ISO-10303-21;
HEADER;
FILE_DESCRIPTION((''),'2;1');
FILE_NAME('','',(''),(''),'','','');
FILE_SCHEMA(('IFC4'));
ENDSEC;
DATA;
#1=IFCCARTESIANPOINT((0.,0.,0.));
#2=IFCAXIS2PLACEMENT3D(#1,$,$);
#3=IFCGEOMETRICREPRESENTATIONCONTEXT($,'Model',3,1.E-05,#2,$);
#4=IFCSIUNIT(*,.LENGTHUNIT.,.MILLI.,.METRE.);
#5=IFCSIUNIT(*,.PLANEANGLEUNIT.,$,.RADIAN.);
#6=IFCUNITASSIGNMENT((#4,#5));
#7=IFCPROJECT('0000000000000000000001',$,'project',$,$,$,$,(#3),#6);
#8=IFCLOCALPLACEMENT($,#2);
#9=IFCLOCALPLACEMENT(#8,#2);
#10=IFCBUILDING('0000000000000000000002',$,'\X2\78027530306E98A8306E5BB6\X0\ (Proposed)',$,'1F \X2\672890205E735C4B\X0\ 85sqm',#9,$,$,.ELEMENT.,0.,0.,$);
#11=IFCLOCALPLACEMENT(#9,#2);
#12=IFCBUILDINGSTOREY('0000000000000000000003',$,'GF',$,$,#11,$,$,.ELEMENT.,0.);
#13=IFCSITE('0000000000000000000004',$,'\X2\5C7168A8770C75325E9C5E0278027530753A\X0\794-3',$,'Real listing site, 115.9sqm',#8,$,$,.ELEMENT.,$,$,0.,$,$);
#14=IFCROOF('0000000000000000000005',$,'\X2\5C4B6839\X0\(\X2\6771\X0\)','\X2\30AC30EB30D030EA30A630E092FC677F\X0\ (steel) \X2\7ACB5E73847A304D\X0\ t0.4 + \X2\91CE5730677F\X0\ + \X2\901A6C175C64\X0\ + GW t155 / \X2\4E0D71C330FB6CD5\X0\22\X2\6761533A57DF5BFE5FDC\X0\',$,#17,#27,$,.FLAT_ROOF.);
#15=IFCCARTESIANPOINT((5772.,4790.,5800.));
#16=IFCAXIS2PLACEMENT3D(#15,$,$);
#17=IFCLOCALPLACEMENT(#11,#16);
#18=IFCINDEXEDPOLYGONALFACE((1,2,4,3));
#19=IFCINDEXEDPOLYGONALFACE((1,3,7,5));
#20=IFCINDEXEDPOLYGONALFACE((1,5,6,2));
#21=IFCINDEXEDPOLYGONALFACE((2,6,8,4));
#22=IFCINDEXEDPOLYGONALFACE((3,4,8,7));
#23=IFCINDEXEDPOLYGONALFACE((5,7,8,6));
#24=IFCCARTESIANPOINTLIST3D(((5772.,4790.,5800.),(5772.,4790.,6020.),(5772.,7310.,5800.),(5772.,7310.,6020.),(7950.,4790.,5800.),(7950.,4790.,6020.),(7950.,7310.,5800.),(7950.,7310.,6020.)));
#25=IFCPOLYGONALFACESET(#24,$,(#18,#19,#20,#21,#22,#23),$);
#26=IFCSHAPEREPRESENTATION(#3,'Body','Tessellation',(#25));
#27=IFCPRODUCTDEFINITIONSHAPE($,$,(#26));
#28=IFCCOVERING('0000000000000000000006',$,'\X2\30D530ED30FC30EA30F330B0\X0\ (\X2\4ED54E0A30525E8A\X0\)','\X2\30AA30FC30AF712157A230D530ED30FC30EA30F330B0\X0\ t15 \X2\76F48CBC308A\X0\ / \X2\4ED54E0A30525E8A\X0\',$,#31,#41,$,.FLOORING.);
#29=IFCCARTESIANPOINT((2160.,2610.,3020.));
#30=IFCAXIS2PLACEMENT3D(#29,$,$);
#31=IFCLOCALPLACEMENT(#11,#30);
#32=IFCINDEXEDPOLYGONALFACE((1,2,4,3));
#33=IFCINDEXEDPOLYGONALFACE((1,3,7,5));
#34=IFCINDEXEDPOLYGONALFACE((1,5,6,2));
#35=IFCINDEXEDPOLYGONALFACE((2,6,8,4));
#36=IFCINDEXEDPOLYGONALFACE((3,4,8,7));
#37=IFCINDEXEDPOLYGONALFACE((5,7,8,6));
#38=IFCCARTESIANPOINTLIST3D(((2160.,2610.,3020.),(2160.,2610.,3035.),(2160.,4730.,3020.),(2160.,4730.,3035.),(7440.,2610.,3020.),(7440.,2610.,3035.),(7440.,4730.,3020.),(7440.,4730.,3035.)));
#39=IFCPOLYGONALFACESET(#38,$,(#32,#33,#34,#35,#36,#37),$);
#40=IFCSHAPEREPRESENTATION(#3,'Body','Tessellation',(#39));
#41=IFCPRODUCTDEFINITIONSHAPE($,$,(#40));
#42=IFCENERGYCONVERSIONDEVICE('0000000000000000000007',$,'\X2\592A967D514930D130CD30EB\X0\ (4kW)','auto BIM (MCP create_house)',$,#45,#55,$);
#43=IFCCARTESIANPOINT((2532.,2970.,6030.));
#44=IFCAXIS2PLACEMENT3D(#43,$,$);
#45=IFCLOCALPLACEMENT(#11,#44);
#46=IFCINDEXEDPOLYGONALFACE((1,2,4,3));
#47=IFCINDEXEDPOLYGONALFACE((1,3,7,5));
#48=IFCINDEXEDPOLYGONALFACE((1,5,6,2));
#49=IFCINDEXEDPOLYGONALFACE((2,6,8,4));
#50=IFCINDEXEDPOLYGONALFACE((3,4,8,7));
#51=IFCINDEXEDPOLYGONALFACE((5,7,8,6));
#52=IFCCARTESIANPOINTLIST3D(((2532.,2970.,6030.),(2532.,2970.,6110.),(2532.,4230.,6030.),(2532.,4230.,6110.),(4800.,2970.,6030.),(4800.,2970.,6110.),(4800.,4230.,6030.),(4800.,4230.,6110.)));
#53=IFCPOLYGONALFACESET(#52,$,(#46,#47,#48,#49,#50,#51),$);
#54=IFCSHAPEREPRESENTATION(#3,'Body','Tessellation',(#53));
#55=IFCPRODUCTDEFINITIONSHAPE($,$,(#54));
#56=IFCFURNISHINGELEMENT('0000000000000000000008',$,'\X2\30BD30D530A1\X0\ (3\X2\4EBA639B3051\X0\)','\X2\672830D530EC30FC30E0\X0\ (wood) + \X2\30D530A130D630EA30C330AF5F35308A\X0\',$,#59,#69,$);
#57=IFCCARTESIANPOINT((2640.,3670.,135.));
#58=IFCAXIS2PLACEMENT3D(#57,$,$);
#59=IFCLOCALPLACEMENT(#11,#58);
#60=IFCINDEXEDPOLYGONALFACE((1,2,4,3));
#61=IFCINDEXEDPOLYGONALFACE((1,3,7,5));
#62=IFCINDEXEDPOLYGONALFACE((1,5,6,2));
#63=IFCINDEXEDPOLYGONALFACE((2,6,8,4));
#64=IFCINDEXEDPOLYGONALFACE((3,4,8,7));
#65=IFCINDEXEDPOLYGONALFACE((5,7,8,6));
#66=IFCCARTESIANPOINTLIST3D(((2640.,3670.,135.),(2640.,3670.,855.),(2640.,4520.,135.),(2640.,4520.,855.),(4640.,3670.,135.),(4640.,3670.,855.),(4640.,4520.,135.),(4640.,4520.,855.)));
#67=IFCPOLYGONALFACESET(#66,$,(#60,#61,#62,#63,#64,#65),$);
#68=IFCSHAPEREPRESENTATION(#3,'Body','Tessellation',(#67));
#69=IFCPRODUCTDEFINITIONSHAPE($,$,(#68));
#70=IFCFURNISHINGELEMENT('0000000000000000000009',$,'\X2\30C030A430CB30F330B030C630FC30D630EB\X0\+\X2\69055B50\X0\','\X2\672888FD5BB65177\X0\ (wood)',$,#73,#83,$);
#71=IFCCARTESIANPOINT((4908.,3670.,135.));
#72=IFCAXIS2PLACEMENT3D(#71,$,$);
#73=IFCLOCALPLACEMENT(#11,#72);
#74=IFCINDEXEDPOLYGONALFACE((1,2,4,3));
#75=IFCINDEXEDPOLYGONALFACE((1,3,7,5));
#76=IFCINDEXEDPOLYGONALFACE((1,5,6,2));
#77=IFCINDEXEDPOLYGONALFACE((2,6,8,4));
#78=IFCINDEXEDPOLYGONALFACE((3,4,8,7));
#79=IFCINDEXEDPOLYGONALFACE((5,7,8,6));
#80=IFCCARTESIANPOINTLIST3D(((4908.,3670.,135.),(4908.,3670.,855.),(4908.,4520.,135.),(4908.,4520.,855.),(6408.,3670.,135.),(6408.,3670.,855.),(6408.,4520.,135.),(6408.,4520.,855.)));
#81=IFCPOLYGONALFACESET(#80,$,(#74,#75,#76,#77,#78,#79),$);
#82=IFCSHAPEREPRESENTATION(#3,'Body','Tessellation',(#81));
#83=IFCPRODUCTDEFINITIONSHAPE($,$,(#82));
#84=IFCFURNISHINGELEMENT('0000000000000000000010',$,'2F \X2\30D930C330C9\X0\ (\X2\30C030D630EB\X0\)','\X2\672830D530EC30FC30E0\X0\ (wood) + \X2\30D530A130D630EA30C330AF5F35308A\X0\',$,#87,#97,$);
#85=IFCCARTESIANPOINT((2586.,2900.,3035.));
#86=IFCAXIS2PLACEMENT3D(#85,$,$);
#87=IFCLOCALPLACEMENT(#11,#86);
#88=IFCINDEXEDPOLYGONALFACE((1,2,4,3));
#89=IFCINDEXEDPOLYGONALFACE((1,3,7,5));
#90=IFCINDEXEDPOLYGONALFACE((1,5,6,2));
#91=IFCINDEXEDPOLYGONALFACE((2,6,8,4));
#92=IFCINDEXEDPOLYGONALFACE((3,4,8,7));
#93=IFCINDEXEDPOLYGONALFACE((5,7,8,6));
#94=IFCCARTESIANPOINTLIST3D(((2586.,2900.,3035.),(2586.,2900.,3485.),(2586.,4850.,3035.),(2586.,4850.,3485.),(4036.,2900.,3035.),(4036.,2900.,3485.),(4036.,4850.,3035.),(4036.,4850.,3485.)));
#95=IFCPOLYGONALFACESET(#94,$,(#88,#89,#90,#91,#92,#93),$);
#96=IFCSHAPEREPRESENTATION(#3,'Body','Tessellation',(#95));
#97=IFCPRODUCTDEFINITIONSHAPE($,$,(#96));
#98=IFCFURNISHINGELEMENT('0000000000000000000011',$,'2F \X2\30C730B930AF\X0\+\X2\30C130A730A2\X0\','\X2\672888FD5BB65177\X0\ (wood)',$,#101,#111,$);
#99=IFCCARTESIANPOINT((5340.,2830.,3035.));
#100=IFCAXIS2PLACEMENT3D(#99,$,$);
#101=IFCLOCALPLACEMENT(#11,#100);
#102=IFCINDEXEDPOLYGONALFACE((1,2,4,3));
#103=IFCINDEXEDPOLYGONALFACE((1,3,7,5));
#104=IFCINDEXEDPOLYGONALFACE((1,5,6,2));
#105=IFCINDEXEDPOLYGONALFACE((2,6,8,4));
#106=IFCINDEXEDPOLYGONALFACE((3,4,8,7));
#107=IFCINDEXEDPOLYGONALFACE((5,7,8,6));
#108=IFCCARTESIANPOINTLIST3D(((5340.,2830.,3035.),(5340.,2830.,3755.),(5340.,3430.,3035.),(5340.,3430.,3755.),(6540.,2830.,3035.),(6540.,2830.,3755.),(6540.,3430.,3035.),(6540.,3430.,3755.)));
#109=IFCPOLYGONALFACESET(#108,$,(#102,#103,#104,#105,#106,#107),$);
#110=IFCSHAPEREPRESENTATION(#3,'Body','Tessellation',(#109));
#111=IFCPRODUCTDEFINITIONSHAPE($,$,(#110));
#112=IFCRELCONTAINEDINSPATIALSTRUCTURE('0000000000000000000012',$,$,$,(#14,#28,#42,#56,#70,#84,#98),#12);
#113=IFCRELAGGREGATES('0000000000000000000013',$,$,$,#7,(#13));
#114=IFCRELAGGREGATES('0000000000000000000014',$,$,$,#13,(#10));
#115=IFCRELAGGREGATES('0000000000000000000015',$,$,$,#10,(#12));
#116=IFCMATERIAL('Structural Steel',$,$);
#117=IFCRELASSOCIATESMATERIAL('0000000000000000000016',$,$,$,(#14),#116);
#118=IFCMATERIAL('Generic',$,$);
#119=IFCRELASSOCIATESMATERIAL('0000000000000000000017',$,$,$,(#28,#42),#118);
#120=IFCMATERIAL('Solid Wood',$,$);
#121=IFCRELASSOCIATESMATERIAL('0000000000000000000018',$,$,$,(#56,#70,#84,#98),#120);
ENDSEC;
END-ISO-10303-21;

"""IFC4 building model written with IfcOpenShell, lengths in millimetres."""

from ifc_helpers import new_model, si_unit, frame, frame_2d, origin, place, context, project, spatial, rectangle, extrude, material, element, save


model = new_model("IFC4")

# Units and contexts
model_context = context("Model", 3, precision=1e-05, world=origin())
ifc_project = project(units=[si_unit("LENGTHUNIT", "METRE", prefix="MILLI"), si_unit("PLANEANGLEUNIT", "RADIAN")], contexts=[model_context])

# Site, building, storey
site_placement = place(None, origin())
site = spatial("IfcSite", under=ifc_project, at=site_placement, Name="山梨県甲府市砂田町794-3", ObjectType="Real listing site, 115.9sqm", CompositionType="ELEMENT", RefElevation=0.0)
building_placement = place(site_placement, origin())
building = spatial("IfcBuilding", under=site, at=building_placement, Name="砂田の風の家 (Proposed)", ObjectType="1F 木造平屋 85sqm", CompositionType="ELEMENT", ElevationOfRefHeight=0.0, ElevationOfTerrain=0.0)
storey_placement = place(building_placement, origin())
storey = spatial("IfcBuildingStorey", under=building, at=storey_placement, Name="GF", CompositionType="ELEMENT", Elevation=0.0)

# Shared definitions
ifc_material_1 = material(Name="Solid Wood")

# Roof
ifc_material_2 = material(Name="Structural Steel")
roof_1_placement = place(storey_placement, frame((5772.0, 4790.0, 5800.0)))
element("IfcRoof", 1, at=roof_1_placement, inside=storey, material=ifc_material_2, Name="屋根(東)", Description="ガルバリウム鋼板 (steel) 立平葺き t0.4 + 野地板 + 通気層 + GW t155 / 不燃・法22条区域対応", PredefinedType="FLAT_ROOF", context=model_context, shape_type="SweptSolid", body=[
    extrude(rectangle(XDim=2178.0, YDim=2520.0, at=frame_2d((1089.0, 1260.0))), frame((5772.0, 4790.0, 5800.0)), (0.0, 0.0, 1.0), 220.0),
])

# Covering
ifc_material_3 = material(Name="Generic")
covering_placement = place(storey_placement, frame((2160.0, 2610.0, 3020.0)))
element("IfcCovering", 2, at=covering_placement, inside=storey, material=ifc_material_3, Name="フローリング (仕上げ床)", Description="オーク無垢フローリング t15 直貼り / 仕上げ床", PredefinedType="FLOORING", context=model_context, shape_type="SweptSolid", body=[
    extrude(rectangle(XDim=5280.0, YDim=2120.0, at=frame_2d((2640.0, 1060.0))), frame((2160.0, 2610.0, 3020.0)), (0.0, 0.0, 1.0), 15.0),
])

# Energy conversion device
energy_conversion_device_placement = place(storey_placement, frame((2532.0, 2970.0, 6030.0)))
element("IfcEnergyConversionDevice", 3, at=energy_conversion_device_placement, inside=storey, material=ifc_material_3, Name="太陽光パネル (4kW)", Description="auto BIM (MCP create_house)", context=model_context, shape_type="SweptSolid", body=[
    extrude(rectangle(XDim=2268.0, YDim=1260.0, at=frame_2d((1134.0, 630.0))), frame((2532.0, 2970.0, 6030.0)), (0.0, 0.0, 1.0), 80.0),
])

# Furnishing elements
furnishing_1_placement = place(storey_placement, frame((2640.0, 3670.0, 135.0)))
element("IfcFurnishingElement", 4, at=furnishing_1_placement, inside=storey, material=ifc_material_1, Name="ソファ (3人掛け)", Description="木フレーム (wood) + ファブリック張り", context=model_context, shape_type="SweptSolid", body=[
    extrude(rectangle(XDim=2000.0, YDim=850.0, at=frame_2d((1000.0, 425.0))), frame((2640.0, 3670.0, 135.0)), (0.0, 0.0, 1.0), 720.0),
])
furnishing_2_placement = place(storey_placement, frame((4908.0, 3670.0, 135.0)))
element("IfcFurnishingElement", 5, at=furnishing_2_placement, inside=storey, material=ifc_material_1, Name="ダイニングテーブル+椅子", Description="木製家具 (wood)", context=model_context, shape_type="SweptSolid", body=[
    extrude(rectangle(XDim=1500.0, YDim=850.0, at=frame_2d((750.0, 425.0))), frame((4908.0, 3670.0, 135.0)), (0.0, 0.0, 1.0), 720.0),
])
furnishing_3_placement = place(storey_placement, frame((2586.0, 2900.0, 3035.0)))
element("IfcFurnishingElement", 6, at=furnishing_3_placement, inside=storey, material=ifc_material_1, Name="2F ベッド (ダブル)", Description="木フレーム (wood) + ファブリック張り", context=model_context, shape_type="SweptSolid", body=[
    extrude(rectangle(XDim=1450.0, YDim=1950.0, at=frame_2d((725.0, 975.0))), frame((2586.0, 2900.0, 3035.0)), (0.0, 0.0, 1.0), 450.0),
])
furnishing_4_placement = place(storey_placement, frame((5340.0, 2830.0, 3035.0)))
element("IfcFurnishingElement", 7, at=furnishing_4_placement, inside=storey, material=ifc_material_1, Name="2F デスク+チェア", Description="木製家具 (wood)", context=model_context, shape_type="SweptSolid", body=[
    extrude(rectangle(XDim=1200.0, YDim=600.0, at=frame_2d((600.0, 300.0))), frame((5340.0, 2830.0, 3035.0)), (0.0, 0.0, 1.0), 720.0),
])

save(model, "model.ifc")
